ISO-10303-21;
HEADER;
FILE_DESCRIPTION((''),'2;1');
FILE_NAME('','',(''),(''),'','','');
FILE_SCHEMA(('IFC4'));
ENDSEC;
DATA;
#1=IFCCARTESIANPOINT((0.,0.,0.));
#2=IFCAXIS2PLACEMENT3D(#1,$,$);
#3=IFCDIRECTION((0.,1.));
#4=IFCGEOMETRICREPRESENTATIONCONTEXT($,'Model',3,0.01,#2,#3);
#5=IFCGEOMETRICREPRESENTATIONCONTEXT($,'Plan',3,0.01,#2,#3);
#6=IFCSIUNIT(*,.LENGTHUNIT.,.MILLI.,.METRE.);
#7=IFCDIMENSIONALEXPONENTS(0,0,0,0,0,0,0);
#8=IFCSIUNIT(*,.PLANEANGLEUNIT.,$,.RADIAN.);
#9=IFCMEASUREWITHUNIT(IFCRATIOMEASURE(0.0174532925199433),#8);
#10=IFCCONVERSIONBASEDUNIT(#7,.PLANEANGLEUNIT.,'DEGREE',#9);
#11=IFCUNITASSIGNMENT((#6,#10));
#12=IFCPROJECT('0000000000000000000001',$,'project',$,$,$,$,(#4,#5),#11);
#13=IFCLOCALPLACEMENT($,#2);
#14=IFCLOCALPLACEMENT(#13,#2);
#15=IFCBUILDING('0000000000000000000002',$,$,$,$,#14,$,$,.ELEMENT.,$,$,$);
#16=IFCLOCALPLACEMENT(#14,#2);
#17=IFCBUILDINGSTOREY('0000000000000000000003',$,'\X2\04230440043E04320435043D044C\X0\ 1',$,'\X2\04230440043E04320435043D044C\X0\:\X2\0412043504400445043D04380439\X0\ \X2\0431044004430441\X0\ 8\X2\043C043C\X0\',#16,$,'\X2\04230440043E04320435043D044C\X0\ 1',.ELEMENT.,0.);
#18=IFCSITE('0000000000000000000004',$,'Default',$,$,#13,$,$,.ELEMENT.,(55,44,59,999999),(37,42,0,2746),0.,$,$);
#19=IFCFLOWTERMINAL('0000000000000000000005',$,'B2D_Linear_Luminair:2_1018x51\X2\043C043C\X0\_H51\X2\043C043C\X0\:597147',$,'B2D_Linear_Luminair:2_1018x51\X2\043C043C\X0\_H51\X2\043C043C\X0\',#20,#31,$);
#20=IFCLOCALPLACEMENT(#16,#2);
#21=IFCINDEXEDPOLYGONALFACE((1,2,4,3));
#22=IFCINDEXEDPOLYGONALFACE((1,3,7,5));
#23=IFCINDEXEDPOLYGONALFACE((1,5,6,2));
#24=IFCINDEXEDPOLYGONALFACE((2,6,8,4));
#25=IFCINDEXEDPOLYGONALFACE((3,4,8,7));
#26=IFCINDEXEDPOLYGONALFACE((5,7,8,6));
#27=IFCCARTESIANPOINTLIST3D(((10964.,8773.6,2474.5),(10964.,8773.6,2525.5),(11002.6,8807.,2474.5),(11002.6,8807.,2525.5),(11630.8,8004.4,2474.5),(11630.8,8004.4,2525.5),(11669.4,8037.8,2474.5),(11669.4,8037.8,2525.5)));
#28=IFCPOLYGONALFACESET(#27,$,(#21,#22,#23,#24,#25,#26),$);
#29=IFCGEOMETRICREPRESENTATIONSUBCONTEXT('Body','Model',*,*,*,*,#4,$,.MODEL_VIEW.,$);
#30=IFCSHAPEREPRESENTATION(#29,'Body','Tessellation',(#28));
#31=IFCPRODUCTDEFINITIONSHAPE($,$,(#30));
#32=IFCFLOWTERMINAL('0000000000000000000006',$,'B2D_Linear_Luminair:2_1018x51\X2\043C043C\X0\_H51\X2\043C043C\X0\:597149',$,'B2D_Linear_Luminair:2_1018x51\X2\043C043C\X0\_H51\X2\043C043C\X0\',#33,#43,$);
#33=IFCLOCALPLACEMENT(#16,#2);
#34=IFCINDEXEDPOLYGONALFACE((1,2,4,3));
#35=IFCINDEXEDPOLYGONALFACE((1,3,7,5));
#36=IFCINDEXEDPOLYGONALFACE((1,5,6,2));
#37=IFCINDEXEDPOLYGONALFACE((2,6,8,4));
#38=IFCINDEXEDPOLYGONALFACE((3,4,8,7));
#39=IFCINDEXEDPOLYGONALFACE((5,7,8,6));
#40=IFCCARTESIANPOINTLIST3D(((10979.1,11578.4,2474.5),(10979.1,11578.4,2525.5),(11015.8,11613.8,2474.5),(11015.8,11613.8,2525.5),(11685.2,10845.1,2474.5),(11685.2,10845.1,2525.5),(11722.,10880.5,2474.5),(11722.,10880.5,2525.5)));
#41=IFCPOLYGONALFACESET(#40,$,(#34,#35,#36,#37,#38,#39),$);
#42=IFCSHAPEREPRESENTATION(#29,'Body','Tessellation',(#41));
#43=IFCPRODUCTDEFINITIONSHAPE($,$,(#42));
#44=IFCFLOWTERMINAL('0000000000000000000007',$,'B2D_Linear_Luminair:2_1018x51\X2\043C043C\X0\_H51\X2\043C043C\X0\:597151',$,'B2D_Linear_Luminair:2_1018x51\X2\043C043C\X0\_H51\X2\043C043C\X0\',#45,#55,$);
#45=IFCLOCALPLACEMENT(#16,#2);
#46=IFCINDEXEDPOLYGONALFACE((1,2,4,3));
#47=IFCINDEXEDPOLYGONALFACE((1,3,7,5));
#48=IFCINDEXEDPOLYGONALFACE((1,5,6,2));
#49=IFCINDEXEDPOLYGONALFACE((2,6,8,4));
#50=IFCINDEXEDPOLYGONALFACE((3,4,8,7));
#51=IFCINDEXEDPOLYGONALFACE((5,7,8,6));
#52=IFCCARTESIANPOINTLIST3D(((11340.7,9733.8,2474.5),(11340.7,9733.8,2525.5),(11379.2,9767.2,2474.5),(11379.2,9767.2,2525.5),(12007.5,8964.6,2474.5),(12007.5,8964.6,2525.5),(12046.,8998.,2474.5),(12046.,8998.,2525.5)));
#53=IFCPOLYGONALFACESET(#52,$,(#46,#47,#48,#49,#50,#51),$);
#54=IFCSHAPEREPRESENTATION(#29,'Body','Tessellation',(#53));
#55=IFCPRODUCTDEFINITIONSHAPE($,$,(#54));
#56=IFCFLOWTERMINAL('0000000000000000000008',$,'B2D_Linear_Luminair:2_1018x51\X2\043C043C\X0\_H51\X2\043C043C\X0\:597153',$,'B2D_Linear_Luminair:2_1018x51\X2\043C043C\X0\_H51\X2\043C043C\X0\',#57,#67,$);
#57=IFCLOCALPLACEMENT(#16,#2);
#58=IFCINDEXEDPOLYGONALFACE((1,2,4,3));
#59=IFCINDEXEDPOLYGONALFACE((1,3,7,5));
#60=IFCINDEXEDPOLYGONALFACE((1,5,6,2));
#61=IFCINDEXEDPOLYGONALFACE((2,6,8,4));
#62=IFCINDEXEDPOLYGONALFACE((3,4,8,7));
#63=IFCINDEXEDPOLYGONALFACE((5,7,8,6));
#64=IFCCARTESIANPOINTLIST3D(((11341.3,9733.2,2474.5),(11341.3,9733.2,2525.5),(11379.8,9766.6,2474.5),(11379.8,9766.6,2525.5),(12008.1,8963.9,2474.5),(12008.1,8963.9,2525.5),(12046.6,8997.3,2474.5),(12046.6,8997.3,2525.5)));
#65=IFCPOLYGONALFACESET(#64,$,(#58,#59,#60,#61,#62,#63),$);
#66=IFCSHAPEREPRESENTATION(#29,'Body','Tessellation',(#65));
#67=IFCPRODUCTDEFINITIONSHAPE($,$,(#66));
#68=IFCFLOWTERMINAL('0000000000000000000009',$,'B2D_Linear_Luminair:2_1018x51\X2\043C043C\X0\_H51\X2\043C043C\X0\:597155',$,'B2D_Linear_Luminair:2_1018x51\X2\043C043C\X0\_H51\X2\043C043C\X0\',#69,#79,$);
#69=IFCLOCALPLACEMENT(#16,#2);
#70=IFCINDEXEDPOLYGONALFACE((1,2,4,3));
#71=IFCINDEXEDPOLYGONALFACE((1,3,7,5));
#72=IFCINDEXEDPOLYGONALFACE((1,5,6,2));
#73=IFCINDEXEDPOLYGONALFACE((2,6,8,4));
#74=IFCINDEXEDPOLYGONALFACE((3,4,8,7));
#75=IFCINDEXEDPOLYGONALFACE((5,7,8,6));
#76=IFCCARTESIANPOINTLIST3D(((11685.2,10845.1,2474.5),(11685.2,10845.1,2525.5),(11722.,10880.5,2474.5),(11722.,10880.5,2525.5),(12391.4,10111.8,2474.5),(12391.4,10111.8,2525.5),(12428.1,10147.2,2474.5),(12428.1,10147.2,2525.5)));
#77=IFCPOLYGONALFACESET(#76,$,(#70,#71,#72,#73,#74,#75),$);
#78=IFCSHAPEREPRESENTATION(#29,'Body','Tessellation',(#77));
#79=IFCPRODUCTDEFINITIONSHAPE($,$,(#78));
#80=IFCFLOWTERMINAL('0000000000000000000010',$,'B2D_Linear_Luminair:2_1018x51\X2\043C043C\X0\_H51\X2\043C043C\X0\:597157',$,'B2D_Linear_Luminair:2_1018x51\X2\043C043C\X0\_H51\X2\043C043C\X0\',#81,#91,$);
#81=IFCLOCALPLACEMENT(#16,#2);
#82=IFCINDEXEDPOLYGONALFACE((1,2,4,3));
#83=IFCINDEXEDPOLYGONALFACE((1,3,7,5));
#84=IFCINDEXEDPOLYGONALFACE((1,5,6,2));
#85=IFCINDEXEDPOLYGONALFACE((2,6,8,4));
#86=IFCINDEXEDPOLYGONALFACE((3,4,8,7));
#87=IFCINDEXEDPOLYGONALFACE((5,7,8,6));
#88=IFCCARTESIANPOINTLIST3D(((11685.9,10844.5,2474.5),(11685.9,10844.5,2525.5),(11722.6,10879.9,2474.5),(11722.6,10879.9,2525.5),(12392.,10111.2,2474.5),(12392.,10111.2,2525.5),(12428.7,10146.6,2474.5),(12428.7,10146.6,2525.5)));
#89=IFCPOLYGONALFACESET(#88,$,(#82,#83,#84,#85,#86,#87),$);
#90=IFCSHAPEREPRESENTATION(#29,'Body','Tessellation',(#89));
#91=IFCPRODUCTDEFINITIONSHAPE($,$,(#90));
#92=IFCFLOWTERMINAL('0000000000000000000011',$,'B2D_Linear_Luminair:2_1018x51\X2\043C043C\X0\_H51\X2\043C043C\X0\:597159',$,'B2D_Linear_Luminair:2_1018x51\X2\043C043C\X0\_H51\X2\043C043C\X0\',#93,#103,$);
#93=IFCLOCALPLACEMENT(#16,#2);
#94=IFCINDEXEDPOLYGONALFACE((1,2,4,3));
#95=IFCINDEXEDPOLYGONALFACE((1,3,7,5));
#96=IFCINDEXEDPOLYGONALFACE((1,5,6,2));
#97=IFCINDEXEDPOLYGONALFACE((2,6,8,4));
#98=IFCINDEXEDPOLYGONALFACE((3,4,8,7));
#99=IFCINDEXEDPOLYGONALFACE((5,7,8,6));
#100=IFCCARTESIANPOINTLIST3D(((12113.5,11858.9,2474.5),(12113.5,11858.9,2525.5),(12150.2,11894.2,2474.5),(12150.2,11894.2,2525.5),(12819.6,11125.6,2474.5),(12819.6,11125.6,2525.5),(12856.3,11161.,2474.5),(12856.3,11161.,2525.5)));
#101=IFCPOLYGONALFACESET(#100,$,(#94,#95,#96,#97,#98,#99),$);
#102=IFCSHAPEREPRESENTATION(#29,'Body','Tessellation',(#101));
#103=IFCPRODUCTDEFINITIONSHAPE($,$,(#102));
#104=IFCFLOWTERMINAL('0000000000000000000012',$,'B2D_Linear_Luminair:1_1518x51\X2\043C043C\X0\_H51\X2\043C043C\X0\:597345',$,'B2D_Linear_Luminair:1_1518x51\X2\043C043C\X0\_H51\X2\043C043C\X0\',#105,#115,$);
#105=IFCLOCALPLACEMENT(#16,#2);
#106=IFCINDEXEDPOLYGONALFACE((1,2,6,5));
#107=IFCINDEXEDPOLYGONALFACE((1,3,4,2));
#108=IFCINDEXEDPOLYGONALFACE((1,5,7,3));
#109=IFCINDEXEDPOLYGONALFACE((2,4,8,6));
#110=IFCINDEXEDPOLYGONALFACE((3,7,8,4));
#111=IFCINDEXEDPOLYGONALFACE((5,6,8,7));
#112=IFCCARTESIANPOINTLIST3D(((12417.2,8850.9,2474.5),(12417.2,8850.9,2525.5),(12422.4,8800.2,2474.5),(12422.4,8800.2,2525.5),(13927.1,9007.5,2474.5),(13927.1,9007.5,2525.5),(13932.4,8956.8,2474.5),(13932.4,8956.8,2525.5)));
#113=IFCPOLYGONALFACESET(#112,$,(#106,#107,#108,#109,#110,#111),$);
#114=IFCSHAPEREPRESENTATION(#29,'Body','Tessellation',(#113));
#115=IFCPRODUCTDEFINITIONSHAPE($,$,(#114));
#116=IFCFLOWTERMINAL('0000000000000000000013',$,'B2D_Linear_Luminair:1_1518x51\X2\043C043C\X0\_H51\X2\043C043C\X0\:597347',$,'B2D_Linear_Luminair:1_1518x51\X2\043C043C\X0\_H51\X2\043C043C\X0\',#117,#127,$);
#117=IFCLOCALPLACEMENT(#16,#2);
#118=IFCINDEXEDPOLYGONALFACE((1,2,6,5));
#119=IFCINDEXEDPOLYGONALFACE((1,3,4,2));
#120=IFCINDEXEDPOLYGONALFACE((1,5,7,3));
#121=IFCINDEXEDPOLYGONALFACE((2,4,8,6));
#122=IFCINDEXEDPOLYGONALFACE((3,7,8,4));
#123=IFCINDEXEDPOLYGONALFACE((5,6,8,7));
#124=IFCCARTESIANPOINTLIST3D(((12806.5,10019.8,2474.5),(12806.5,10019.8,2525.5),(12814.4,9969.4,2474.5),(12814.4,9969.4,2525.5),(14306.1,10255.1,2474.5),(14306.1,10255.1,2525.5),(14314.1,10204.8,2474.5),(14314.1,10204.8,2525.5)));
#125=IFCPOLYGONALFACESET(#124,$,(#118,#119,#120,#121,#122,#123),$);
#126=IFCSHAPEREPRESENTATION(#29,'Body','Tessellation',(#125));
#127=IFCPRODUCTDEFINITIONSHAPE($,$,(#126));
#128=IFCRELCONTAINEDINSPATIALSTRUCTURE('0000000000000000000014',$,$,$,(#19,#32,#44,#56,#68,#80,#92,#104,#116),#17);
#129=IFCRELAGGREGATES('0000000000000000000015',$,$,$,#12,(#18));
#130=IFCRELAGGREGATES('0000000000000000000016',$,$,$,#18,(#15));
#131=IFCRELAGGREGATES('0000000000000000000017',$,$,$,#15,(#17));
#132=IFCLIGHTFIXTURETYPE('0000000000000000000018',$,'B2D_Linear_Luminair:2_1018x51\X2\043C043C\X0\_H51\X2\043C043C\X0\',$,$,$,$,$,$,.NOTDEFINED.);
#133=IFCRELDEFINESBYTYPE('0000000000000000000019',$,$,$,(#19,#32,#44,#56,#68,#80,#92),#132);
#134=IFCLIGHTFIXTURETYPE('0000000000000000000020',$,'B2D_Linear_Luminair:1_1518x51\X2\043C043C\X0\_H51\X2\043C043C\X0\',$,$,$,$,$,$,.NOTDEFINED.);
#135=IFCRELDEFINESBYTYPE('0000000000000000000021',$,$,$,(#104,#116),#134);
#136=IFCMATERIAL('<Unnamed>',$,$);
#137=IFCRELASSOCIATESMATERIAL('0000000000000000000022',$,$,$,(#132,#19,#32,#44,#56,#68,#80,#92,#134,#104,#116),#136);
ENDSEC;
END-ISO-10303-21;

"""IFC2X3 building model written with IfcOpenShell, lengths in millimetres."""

from ifc_helpers import new_model, entity, si_unit, converted_unit, direction, frame, origin, origin_2d_with_axis, place, context, subcontext, project, spatial, rectangle, extrude, source, transform, mapped, material, type_object, type_shapes, element, save


model = new_model("IFC2X3")

# Units and contexts
model_context = context("Model", 3, precision=0.01, world=origin(), true_north=direction((0.0, 1.0)))
plan_context = context("Plan", 3, precision=0.01, world=origin(), true_north=direction((0.0, 1.0)))
body_context = subcontext(model_context, "Body", "Model", "MODEL_VIEW")
ifc_project = project(units=[si_unit("LENGTHUNIT", "METRE", prefix="MILLI"), converted_unit("PLANEANGLEUNIT", "DEGREE", entity("IfcRatioMeasure", 0.0174532925199433), si_unit("PLANEANGLEUNIT", "RADIAN"), dimensions=[0, 0, 0, 0, 0, 0, 0])], contexts=[model_context, plan_context])

# Site, building, storey
site_placement = place(None, origin())
site = spatial("IfcSite", under=ifc_project, at=site_placement, Name="Default", CompositionType="ELEMENT", RefLatitude=(55, 44, 59, 999999), RefLongitude=(37, 42, 0, 2746), RefElevation=0.0)
building_placement = place(site_placement, origin())
building = spatial("IfcBuilding", under=site, at=building_placement, CompositionType="ELEMENT")
storey_placement = place(building_placement, origin())
storey = spatial("IfcBuildingStorey", under=building, at=storey_placement, Name="Уровень 1", ObjectType="Уровень:Верхний брус 8мм", LongName="Уровень 1", CompositionType="ELEMENT", Elevation=0.0)

# Flow terminals
ifc_material = material(Name="<Unnamed>")
light_fixture_type_1 = type_object("IfcLightFixtureType", Name="B2D_Linear_Luminair:2_1018x51мм_H51мм", PredefinedType="NOTDEFINED", material=ifc_material)
shared_shape_1 = source(origin(), body_context, "Body", "SweptSolid", [
    extrude(rectangle(XDim=1018.0, YDim=51.0, at=origin_2d_with_axis()), frame((0.0, 0.0, 0.0), z_axis=(0.0, 0.0, 1.0), x_axis=(-1.0, 0.0, 0.0)), (0.0, 0.0, 1.0), 51.0),
])
type_shapes(light_fixture_type_1, [shared_shape_1])
for number, where, z_axis, x_axis, name in (
    (1, (11316.7, 8405.7, 2525.5), (0.0, 0.0, -1.0), (0.655005, -0.755625, 0.0), "B2D_Linear_Luminair:2_1018x51мм_H51мм:597147"),
    (2, (11350.5, 11229.4, 2525.5), (0.0, 0.0, -1.0), (0.693653, -0.720309, 0.0), "B2D_Linear_Luminair:2_1018x51мм_H51мм:597149"),
    (3, (11693.3, 9365.9, 2525.5), (0.0, 0.0, -1.0), (0.655005, -0.755625, 0.0), "B2D_Linear_Luminair:2_1018x51мм_H51мм:597151"),
    (4, (11693.9, 9365.2, 2525.5), (0.0, 0.0, -1.0), (0.655005, -0.755625, 0.0), "B2D_Linear_Luminair:2_1018x51мм_H51мм:597153"),
    (5, (12056.7, 10496.2, 2525.5), (0.0, 0.0, -1.0), (0.693653, -0.720309, 0.0), "B2D_Linear_Luminair:2_1018x51мм_H51мм:597155"),
    (6, (12057.3, 10495.5, 2525.5), (0.0, 0.0, -1.0), (0.693653, -0.720309, 0.0), "B2D_Linear_Luminair:2_1018x51мм_H51мм:597157"),
    (7, (12484.9, 11509.9, 2525.5), (0.0, 0.0, -1.0), (0.693653, -0.720309, 0.0), "B2D_Linear_Luminair:2_1018x51мм_H51мм:597159"),
):
    element("IfcFlowTerminal", number, at=place(storey_placement, frame(where, z_axis=z_axis, x_axis=x_axis)), inside=storey, type_object=light_fixture_type_1, material=ifc_material, Name=name, ObjectType="B2D_Linear_Luminair:2_1018x51мм_H51мм", context=body_context, shape_type="MappedRepresentation", body=[
        mapped(shared_shape_1, transform((0.0, 0.0, 0.0), scale=1.0)),
    ])
light_fixture_type_2 = type_object("IfcLightFixtureType", Name="B2D_Linear_Luminair:1_1518x51мм_H51мм", PredefinedType="NOTDEFINED", material=ifc_material)
shared_shape_2 = source(origin(), body_context, "Body", "SweptSolid", [
    extrude(rectangle(XDim=1518.0, YDim=51.0, at=origin_2d_with_axis()), frame((0.0, 0.0, 0.0), z_axis=(0.0, 0.0, 1.0), x_axis=(-1.0, 0.0, 0.0)), (0.0, 0.0, 1.0), 51.0),
])
type_shapes(light_fixture_type_2, [shared_shape_2])
for number, where, z_axis, x_axis, name in (
    (8, (13174.8, 8903.8, 2525.5), (0.0, 0.0, -1.0), (0.994667, 0.10314, 0.0), "B2D_Linear_Luminair:1_1518x51мм_H51мм:597345"),
    (9, (13560.3, 10112.3, 2525.5), (0.0, 0.0, -1.0), (0.987906, 0.155055, 0.0), "B2D_Linear_Luminair:1_1518x51мм_H51мм:597347"),
):
    element("IfcFlowTerminal", number, at=place(storey_placement, frame(where, z_axis=z_axis, x_axis=x_axis)), inside=storey, type_object=light_fixture_type_2, material=ifc_material, Name=name, ObjectType="B2D_Linear_Luminair:1_1518x51мм_H51мм", context=body_context, shape_type="MappedRepresentation", body=[
        mapped(shared_shape_2, transform((0.0, 0.0, 0.0), scale=1.0)),
    ])

save(model, "model.ifc")
